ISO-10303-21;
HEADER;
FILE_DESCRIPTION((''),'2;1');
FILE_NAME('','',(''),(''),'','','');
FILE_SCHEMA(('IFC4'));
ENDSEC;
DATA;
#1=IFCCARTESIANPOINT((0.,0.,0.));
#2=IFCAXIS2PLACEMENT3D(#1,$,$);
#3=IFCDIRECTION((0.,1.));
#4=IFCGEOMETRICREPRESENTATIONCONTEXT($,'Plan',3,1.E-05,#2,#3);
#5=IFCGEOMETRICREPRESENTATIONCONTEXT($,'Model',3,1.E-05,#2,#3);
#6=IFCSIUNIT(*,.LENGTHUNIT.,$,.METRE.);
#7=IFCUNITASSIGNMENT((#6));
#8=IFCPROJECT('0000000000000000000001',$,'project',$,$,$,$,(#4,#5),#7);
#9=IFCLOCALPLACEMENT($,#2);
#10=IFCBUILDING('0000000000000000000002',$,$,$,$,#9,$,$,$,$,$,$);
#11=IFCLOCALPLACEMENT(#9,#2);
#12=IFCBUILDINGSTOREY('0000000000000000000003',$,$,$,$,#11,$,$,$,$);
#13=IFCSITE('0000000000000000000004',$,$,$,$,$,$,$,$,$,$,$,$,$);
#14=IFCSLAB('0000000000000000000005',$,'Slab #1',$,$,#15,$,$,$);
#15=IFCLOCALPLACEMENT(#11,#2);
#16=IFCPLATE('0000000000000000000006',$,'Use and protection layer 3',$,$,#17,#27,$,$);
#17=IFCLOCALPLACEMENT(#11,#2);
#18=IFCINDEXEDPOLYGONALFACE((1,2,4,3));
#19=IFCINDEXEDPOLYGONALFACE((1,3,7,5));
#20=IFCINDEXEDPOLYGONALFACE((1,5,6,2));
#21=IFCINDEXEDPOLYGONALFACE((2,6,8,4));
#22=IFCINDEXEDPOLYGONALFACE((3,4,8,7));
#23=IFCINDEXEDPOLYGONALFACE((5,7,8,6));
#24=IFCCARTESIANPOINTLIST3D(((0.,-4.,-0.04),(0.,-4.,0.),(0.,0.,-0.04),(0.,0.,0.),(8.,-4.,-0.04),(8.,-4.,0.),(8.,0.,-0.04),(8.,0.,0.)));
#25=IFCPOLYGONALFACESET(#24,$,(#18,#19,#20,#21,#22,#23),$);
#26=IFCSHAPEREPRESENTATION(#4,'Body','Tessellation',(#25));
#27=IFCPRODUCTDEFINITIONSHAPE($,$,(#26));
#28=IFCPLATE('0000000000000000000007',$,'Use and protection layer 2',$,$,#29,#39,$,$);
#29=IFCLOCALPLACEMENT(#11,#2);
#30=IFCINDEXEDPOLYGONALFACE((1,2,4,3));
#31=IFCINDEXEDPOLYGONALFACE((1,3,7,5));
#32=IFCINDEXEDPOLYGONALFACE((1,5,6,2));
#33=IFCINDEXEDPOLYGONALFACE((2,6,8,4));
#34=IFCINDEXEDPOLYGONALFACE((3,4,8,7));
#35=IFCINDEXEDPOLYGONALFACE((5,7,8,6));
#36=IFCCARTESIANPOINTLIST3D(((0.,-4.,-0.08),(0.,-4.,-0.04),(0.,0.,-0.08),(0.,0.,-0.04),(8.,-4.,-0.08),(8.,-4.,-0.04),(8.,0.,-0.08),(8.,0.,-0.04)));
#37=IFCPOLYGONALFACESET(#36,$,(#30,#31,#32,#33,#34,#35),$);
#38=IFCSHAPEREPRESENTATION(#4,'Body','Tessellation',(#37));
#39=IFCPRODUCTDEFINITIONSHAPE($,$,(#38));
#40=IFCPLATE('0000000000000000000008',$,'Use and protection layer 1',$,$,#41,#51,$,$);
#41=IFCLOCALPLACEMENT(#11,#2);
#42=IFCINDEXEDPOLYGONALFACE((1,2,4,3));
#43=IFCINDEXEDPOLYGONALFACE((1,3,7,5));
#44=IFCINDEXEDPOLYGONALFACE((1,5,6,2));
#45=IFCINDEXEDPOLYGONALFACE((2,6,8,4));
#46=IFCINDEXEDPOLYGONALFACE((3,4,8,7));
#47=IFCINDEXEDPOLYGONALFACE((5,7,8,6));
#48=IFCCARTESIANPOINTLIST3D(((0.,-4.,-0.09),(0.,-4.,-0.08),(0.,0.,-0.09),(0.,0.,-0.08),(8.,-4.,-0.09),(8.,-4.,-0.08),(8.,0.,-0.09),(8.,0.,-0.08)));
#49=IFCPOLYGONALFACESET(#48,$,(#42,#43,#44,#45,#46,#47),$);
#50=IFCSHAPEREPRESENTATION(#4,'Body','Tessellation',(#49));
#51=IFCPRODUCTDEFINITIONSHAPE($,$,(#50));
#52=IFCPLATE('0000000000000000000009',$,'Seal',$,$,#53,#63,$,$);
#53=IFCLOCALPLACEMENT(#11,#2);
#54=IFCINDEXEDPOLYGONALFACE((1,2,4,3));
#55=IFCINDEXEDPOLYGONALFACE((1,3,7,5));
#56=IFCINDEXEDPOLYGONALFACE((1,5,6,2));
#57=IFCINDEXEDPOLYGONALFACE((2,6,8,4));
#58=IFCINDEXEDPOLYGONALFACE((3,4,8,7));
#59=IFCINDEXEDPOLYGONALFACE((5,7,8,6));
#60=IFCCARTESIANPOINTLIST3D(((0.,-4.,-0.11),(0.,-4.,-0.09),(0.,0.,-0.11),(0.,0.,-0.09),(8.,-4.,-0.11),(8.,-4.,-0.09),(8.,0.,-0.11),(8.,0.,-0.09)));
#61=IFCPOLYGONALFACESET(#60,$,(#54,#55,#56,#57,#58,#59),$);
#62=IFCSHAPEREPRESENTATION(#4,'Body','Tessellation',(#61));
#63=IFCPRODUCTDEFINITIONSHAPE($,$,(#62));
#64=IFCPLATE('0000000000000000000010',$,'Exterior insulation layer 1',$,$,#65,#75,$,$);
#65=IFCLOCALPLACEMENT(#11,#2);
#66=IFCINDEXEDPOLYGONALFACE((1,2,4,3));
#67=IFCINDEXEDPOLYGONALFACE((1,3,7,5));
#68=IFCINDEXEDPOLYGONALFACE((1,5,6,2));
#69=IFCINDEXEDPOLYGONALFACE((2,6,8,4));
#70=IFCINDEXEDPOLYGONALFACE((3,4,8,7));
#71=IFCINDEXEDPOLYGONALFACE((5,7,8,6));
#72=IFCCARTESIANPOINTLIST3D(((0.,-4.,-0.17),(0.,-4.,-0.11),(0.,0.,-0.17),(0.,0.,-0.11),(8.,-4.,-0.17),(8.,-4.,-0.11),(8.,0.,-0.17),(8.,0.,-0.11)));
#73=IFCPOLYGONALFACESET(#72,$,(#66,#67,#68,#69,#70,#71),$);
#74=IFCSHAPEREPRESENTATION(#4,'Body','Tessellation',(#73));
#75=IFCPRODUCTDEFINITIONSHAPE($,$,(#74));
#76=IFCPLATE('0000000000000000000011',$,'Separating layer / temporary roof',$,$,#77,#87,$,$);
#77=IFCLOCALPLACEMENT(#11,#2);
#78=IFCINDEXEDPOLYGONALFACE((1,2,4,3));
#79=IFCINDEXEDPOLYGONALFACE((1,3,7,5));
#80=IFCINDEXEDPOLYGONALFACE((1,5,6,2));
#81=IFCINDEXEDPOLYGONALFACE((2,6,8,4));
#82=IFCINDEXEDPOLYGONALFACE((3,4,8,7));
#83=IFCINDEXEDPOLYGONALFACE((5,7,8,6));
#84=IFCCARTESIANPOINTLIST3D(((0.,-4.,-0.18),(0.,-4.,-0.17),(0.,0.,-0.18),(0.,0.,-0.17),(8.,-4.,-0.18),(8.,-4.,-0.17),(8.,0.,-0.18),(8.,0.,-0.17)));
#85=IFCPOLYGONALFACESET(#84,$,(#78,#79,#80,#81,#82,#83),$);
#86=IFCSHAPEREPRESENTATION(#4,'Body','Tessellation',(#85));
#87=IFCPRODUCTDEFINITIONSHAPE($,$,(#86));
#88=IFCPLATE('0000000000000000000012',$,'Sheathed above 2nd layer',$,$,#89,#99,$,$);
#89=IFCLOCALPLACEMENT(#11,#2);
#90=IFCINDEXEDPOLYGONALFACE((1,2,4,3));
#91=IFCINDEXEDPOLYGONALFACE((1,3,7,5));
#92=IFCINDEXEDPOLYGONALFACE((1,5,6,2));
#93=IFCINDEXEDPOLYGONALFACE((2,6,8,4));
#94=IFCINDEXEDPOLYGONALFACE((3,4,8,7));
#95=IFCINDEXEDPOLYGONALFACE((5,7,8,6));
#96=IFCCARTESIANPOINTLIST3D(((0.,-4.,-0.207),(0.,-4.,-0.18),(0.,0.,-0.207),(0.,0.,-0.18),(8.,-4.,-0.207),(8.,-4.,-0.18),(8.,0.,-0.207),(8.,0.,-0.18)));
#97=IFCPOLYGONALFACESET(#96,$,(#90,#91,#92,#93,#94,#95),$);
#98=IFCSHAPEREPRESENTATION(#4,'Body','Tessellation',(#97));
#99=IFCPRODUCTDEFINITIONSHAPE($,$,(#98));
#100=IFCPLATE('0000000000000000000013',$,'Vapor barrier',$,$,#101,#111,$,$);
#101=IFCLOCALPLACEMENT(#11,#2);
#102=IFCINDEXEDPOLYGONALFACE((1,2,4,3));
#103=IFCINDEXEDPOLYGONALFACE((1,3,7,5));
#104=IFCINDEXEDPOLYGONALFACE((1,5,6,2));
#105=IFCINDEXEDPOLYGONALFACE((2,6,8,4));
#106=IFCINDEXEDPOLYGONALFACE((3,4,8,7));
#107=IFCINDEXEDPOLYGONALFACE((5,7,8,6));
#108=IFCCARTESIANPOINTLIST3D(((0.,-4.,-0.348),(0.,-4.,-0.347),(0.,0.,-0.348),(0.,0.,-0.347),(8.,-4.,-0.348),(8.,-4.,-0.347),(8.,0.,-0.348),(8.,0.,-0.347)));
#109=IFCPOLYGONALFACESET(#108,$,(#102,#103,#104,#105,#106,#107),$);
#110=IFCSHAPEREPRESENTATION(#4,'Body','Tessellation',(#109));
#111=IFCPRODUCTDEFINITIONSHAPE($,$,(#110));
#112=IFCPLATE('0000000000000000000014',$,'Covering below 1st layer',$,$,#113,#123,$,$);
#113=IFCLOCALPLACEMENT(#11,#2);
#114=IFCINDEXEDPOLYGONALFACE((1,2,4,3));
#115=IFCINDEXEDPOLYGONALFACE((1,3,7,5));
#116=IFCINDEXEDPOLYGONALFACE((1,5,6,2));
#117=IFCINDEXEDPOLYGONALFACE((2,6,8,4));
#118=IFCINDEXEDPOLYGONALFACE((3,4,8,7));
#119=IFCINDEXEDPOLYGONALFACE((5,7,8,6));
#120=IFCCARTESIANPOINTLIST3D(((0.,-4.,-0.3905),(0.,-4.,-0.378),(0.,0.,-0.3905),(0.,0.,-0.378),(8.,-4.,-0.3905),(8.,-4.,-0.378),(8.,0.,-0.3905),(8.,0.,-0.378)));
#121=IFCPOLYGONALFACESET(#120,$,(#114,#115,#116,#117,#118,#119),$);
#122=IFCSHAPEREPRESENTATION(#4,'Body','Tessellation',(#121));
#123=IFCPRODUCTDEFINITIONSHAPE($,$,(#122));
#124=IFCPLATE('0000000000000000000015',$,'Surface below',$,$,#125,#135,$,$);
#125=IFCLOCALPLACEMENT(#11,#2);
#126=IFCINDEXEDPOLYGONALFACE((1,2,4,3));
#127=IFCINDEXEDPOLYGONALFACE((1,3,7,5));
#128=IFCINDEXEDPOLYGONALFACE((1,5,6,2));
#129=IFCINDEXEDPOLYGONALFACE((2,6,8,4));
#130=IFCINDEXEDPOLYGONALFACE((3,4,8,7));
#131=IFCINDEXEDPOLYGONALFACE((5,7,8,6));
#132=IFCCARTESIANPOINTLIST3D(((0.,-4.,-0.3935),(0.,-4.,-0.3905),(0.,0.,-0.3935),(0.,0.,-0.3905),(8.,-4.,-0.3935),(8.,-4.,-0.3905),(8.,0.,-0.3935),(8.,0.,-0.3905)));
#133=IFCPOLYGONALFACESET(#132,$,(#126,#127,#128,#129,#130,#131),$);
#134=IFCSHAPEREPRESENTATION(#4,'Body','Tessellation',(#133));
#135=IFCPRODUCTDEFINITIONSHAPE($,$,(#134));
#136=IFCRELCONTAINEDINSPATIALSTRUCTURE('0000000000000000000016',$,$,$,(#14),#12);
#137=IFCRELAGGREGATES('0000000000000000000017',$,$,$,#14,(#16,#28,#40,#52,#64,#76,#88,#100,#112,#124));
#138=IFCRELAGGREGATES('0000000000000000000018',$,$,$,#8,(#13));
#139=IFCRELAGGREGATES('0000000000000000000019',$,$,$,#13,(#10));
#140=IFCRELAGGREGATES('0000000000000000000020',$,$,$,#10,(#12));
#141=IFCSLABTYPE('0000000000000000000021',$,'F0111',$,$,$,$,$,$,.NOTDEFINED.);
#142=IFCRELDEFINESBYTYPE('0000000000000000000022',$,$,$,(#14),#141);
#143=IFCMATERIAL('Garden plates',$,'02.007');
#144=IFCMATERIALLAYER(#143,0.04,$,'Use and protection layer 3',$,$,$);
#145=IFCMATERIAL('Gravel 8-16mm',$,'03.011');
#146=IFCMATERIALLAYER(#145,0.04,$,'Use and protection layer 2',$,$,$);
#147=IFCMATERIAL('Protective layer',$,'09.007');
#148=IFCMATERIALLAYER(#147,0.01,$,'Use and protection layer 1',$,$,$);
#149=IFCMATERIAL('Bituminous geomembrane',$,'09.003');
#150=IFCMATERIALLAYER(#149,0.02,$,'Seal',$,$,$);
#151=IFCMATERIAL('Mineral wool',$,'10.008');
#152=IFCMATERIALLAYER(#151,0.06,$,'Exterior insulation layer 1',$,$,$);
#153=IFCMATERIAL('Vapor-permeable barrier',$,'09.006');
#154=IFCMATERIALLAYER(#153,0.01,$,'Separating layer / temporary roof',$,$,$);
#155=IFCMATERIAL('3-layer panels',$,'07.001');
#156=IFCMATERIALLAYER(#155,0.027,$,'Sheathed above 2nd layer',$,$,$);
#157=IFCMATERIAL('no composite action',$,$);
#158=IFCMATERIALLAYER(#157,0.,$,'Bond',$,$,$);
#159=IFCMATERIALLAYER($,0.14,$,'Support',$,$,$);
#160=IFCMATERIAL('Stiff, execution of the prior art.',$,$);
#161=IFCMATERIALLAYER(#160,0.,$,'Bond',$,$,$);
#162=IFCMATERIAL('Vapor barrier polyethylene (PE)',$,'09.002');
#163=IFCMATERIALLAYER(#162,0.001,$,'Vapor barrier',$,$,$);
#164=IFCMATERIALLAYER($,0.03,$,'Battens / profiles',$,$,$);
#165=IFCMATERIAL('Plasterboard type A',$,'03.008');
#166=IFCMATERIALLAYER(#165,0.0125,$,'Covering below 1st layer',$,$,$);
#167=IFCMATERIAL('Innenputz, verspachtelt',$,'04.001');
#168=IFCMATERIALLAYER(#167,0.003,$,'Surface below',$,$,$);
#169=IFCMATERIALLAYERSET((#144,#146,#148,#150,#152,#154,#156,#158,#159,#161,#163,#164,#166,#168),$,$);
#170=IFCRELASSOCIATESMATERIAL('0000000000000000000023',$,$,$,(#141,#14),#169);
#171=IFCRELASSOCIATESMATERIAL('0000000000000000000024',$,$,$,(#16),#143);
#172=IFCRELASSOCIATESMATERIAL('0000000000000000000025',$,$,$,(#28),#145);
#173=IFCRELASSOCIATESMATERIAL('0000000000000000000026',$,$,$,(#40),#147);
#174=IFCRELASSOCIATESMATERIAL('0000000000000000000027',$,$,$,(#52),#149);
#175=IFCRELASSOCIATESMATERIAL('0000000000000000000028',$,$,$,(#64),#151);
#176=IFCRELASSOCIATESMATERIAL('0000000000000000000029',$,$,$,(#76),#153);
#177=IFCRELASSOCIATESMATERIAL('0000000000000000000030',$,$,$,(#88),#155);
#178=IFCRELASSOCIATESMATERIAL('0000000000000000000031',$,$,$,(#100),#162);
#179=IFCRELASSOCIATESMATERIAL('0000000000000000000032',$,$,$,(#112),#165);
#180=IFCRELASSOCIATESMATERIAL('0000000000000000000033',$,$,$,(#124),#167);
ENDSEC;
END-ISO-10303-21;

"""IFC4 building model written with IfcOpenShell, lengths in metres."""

from ifc_helpers import new_model, si_unit, direction, frame, frame_2d, origin, origin_with_axes, place, context, project, spatial, rectangle, extrude, material, layer, layer_set, type_object, element, aggregate, save


model = new_model("IFC4")

# Units and contexts
plan_context = context("Plan", 3, precision=1e-05, world=origin(), true_north=direction((0.0, 1.0)))
model_context = context("Model", 3, precision=1e-05, world=origin(), true_north=direction((0.0, 1.0)))
ifc_project = project(units=[si_unit("LENGTHUNIT", "METRE")], contexts=[plan_context, model_context])

# Site, building, storey
site = spatial("IfcSite", under=ifc_project)
building_placement = place(None, origin())
building = spatial("IfcBuilding", under=site, at=building_placement)
storey_placement = place(building_placement, origin())
storey = spatial("IfcBuildingStorey", under=building, at=storey_placement)

# Slab, plates
ifc_material_1 = material(Name="Garden plates", Category="02.007")
ifc_layer_1 = layer(ifc_material_1, 0.04, Name="Use and protection layer 3")
ifc_material_2 = material(Name="Gravel 8-16mm", Category="03.011")
ifc_layer_2 = layer(ifc_material_2, 0.04, Name="Use and protection layer 2")
ifc_material_3 = material(Name="Protective layer", Category="09.007")
ifc_layer_3 = layer(ifc_material_3, 0.01, Name="Use and protection layer 1")
ifc_material_4 = material(Name="Bituminous geomembrane", Category="09.003")
ifc_layer_4 = layer(ifc_material_4, 0.02, Name="Seal")
ifc_material_5 = material(Name="Mineral wool", Category="10.008")
ifc_layer_5 = layer(ifc_material_5, 0.06, Name="Exterior insulation layer 1")
ifc_material_6 = material(Name="Vapor-permeable barrier", Category="09.006")
ifc_layer_6 = layer(ifc_material_6, 0.01, Name="Separating layer / temporary roof")
ifc_material_7 = material(Name="3-layer panels", Category="07.001")
ifc_layer_7 = layer(ifc_material_7, 0.027, Name="Sheathed above 2nd layer")
ifc_material_8 = material(Name="no composite action")
ifc_layer_8 = layer(ifc_material_8, 0.0, Name="Bond")
ifc_layer_9 = layer(None, 0.14, Name="Support")
ifc_material_9 = material(Name="Stiff, execution of the prior art.")
ifc_layer_10 = layer(ifc_material_9, 0.0, Name="Bond")
ifc_material_10 = material(Name="Vapor barrier polyethylene (PE)", Category="09.002")
ifc_layer_11 = layer(ifc_material_10, 0.001, Name="Vapor barrier")
ifc_layer_12 = layer(None, 0.03, Name="Battens / profiles")
ifc_material_11 = material(Name="Plasterboard type A", Category="03.008")
ifc_layer_13 = layer(ifc_material_11, 0.0125, Name="Covering below 1st layer")
ifc_material_12 = material(Name="Innenputz, verspachtelt", Category="04.001")
ifc_layer_14 = layer(ifc_material_12, 0.003, Name="Surface below")
ifc_layer_set = layer_set([ifc_layer_1, ifc_layer_2, ifc_layer_3, ifc_layer_4, ifc_layer_5, ifc_layer_6, ifc_layer_7, ifc_layer_8, ifc_layer_9, ifc_layer_10, ifc_layer_11, ifc_layer_12, ifc_layer_13, ifc_layer_14])
slab_type = type_object("IfcSlabType", Name="F0111", PredefinedType="NOTDEFINED", material=ifc_layer_set)
slab_placement = place(None, frame((0.0, 0.0, 0.0), z_axis=(0.0, 0.0, -1.0), x_axis=(1.0, 0.0, 0.0)))
slab = element("IfcSlab", 1, at=slab_placement, inside=storey, type_object=slab_type, material=ifc_layer_set, Name="Slab #1")
plate_1_placement = place(slab_placement, origin())
plate_1 = element("IfcPlate", 2, at=plate_1_placement, material=ifc_material_1, Name="Use and protection layer 3", context=plan_context, shape_type="SweptSolid", body=[
    extrude(rectangle(XDim=8.0, YDim=4.0, at=frame_2d((4.0, 2.0), x_axis=(1.0, 0.0))), origin_with_axes(), (0.0, 0.0, 1.0), 0.04),
])
plate_2_placement = place(slab_placement, origin())
plate_2 = element("IfcPlate", 3, at=plate_2_placement, material=ifc_material_2, Name="Use and protection layer 2", context=plan_context, shape_type="SweptSolid", body=[
    extrude(rectangle(XDim=8.0, YDim=4.0, at=frame_2d((4.0, 2.0), x_axis=(1.0, 0.0))), frame((0.0, 0.0, 0.04), z_axis=(0.0, 0.0, 1.0), x_axis=(1.0, 0.0, 0.0)), (0.0, 0.0, 1.0), 0.04),
])
plate_3_placement = place(slab_placement, origin())
plate_3 = element("IfcPlate", 4, at=plate_3_placement, material=ifc_material_3, Name="Use and protection layer 1", context=plan_context, shape_type="SweptSolid", body=[
    extrude(rectangle(XDim=8.0, YDim=4.0, at=frame_2d((4.0, 2.0), x_axis=(1.0, 0.0))), frame((0.0, 0.0, 0.08), z_axis=(0.0, 0.0, 1.0), x_axis=(1.0, 0.0, 0.0)), (0.0, 0.0, 1.0), 0.01),
])
plate_4_placement = place(slab_placement, origin())
plate_4 = element("IfcPlate", 5, at=plate_4_placement, material=ifc_material_4, Name="Seal", context=plan_context, shape_type="SweptSolid", body=[
    extrude(rectangle(XDim=8.0, YDim=4.0, at=frame_2d((4.0, 2.0), x_axis=(1.0, 0.0))), frame((0.0, 0.0, 0.09), z_axis=(0.0, 0.0, 1.0), x_axis=(1.0, 0.0, 0.0)), (0.0, 0.0, 1.0), 0.02),
])
plate_5_placement = place(slab_placement, origin())
plate_5 = element("IfcPlate", 6, at=plate_5_placement, material=ifc_material_5, Name="Exterior insulation layer 1", context=plan_context, shape_type="SweptSolid", body=[
    extrude(rectangle(XDim=8.0, YDim=4.0, at=frame_2d((4.0, 2.0), x_axis=(1.0, 0.0))), frame((0.0, 0.0, 0.11), z_axis=(0.0, 0.0, 1.0), x_axis=(1.0, 0.0, 0.0)), (0.0, 0.0, 1.0), 0.06),
])
plate_6_placement = place(slab_placement, origin())
plate_6 = element("IfcPlate", 7, at=plate_6_placement, material=ifc_material_6, Name="Separating layer / temporary roof", context=plan_context, shape_type="SweptSolid", body=[
    extrude(rectangle(XDim=8.0, YDim=4.0, at=frame_2d((4.0, 2.0), x_axis=(1.0, 0.0))), frame((0.0, 0.0, 0.17), z_axis=(0.0, 0.0, 1.0), x_axis=(1.0, 0.0, 0.0)), (0.0, 0.0, 1.0), 0.01),
])
plate_7_placement = place(slab_placement, origin())
plate_7 = element("IfcPlate", 8, at=plate_7_placement, material=ifc_material_7, Name="Sheathed above 2nd layer", context=plan_context, shape_type="SweptSolid", body=[
    extrude(rectangle(XDim=8.0, YDim=4.0, at=frame_2d((4.0, 2.0), x_axis=(1.0, 0.0))), frame((0.0, 0.0, 0.18), z_axis=(0.0, 0.0, 1.0), x_axis=(1.0, 0.0, 0.0)), (0.0, 0.0, 1.0), 0.027),
])
plate_8_placement = place(slab_placement, origin())
plate_8 = element("IfcPlate", 9, at=plate_8_placement, material=ifc_material_10, Name="Vapor barrier", context=plan_context, shape_type="SweptSolid", body=[
    extrude(rectangle(XDim=8.0, YDim=4.0, at=frame_2d((4.0, 2.0), x_axis=(1.0, 0.0))), frame((0.0, 0.0, 0.347), z_axis=(0.0, 0.0, 1.0), x_axis=(1.0, 0.0, 0.0)), (0.0, 0.0, 1.0), 0.001),
])
plate_9_placement = place(slab_placement, origin())
plate_9 = element("IfcPlate", 10, at=plate_9_placement, material=ifc_material_11, Name="Covering below 1st layer", context=plan_context, shape_type="SweptSolid", body=[
    extrude(rectangle(XDim=8.0, YDim=4.0, at=frame_2d((4.0, 2.0), x_axis=(1.0, 0.0))), frame((0.0, 0.0, 0.378), z_axis=(0.0, 0.0, 1.0), x_axis=(1.0, 0.0, 0.0)), (0.0, 0.0, 1.0), 0.0125),
])
plate_10_placement = place(slab_placement, origin())
plate_10 = element("IfcPlate", 11, at=plate_10_placement, material=ifc_material_12, Name="Surface below", context=plan_context, shape_type="SweptSolid", body=[
    extrude(rectangle(XDim=8.0, YDim=4.0, at=frame_2d((4.0, 2.0), x_axis=(1.0, 0.0))), frame((0.0, 0.0, 0.3905), z_axis=(0.0, 0.0, 1.0), x_axis=(1.0, 0.0, 0.0)), (0.0, 0.0, 1.0), 0.003),
])
aggregate(slab, [plate_1, plate_2, plate_3, plate_4, plate_5, plate_6, plate_7, plate_8, plate_9, plate_10])

save(model, "model.ifc")
